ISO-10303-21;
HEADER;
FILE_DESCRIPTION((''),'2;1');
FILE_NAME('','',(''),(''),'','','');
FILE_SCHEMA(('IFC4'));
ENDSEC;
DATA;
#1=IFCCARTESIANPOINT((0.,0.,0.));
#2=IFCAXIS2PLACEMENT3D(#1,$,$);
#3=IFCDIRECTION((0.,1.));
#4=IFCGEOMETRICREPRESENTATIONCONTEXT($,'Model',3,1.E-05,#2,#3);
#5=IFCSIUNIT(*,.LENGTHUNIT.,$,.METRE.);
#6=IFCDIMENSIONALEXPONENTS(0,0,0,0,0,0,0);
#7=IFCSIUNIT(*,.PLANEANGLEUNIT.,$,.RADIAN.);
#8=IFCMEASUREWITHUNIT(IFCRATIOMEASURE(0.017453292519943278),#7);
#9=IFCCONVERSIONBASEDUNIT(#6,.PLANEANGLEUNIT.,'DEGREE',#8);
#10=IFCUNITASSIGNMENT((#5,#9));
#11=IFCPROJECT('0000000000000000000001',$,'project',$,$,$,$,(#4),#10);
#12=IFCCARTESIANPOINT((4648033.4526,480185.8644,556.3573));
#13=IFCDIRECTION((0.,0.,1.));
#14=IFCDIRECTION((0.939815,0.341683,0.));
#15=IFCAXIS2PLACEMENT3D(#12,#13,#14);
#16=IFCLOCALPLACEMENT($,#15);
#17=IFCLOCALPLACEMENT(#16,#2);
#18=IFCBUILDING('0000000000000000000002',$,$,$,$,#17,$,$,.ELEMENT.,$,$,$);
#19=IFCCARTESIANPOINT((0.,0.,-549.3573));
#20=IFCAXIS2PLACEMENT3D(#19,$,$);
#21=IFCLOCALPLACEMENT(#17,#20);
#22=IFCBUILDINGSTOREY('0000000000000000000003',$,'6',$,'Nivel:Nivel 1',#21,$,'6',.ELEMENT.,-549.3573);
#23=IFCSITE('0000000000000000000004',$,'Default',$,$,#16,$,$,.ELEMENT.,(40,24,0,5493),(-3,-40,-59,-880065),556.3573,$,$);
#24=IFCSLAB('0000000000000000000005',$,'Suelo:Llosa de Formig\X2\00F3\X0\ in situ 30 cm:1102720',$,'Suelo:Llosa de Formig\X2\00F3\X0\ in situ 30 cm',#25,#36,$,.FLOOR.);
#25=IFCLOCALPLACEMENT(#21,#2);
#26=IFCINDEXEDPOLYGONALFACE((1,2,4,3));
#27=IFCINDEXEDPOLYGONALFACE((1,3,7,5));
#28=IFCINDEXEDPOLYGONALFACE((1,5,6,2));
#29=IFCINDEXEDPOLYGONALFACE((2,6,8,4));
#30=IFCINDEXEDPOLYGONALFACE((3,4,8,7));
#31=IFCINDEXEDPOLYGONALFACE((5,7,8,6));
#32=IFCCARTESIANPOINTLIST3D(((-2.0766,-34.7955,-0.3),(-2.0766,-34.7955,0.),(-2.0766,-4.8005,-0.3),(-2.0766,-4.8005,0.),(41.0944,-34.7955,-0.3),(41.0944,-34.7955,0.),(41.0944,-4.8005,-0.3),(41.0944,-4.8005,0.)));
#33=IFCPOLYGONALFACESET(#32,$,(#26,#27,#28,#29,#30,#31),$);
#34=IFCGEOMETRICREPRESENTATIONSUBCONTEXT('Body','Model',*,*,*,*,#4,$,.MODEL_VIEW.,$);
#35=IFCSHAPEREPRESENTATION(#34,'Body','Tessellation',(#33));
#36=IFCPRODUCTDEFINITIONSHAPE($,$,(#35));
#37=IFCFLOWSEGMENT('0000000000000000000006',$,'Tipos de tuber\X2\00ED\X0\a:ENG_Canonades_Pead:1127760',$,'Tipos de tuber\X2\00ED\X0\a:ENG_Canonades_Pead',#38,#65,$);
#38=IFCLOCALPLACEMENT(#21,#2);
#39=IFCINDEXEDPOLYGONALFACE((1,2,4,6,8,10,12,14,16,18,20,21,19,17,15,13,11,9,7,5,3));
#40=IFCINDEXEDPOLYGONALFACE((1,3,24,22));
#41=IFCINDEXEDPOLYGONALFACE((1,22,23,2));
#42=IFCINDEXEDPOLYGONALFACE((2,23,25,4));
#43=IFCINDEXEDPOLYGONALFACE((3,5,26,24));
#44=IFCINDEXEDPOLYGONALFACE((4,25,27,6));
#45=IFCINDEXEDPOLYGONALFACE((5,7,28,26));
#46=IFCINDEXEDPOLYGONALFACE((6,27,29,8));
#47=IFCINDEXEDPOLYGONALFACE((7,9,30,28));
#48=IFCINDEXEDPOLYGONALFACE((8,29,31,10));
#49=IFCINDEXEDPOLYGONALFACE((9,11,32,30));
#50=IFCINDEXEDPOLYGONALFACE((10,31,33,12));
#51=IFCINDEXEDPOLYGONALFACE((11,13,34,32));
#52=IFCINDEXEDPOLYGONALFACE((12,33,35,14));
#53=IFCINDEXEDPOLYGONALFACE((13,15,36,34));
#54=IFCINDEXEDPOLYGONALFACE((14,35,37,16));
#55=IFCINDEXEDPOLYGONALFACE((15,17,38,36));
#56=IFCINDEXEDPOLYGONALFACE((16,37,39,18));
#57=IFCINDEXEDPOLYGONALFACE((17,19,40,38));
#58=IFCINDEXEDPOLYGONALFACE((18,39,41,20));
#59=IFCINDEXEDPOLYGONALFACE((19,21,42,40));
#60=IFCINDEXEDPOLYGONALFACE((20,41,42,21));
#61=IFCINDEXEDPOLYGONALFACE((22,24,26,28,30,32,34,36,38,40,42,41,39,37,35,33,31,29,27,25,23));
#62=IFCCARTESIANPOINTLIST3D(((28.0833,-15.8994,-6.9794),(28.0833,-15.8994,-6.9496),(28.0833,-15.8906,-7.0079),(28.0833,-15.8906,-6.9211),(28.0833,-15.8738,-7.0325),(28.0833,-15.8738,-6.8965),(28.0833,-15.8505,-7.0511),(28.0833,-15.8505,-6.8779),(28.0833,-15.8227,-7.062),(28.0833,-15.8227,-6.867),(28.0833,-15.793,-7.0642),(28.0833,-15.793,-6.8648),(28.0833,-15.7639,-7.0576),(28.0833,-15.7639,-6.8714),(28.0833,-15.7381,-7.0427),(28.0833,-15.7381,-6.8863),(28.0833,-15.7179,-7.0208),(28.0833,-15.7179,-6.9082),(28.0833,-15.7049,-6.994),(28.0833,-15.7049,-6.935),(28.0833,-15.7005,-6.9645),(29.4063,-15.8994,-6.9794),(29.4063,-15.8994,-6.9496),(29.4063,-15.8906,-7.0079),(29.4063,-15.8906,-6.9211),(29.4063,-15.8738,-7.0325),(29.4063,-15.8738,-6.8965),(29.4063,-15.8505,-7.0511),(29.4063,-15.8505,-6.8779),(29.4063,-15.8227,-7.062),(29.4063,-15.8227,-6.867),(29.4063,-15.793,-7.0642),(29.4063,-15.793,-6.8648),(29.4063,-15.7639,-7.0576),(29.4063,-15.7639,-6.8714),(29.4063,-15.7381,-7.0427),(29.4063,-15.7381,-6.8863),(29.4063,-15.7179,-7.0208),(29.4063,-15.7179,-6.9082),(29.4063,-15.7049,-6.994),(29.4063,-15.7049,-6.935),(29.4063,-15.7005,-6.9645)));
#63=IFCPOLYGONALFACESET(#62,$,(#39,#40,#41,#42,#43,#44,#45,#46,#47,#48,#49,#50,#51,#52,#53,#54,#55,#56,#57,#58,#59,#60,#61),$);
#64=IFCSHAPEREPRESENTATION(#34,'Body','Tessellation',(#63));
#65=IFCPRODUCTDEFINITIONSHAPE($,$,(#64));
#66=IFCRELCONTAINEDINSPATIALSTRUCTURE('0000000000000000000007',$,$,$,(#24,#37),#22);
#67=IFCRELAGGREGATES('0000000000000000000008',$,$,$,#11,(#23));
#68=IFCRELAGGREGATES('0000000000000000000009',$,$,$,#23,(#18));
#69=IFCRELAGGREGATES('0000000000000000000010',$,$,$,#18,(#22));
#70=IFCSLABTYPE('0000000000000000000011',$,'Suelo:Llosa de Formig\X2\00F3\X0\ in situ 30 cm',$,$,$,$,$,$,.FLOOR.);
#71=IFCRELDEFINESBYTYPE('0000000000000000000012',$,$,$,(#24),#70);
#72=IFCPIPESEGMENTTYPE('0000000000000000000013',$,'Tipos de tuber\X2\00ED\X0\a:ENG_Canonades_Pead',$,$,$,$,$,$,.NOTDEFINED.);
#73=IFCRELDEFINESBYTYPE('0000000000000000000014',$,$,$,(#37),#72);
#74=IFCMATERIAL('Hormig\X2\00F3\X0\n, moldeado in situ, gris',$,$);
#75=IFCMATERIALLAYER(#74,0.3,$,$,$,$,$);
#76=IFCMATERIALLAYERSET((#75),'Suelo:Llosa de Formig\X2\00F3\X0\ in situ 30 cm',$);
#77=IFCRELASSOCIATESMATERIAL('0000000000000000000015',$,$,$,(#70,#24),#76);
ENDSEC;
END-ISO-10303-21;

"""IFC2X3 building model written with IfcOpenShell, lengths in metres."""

from ifc_helpers import new_model, entity, si_unit, converted_unit, direction, frame, frame_2d, origin, origin_2d_with_axis, place, context, subcontext, project, spatial, rectangle, circle, extrude, material, layer, layer_set, layer_usage, type_object, element, save


model = new_model("IFC2X3")

# Units and contexts
model_context = context("Model", 3, precision=1e-05, world=origin(), true_north=direction((0.0, 1.0)))
body_context = subcontext(model_context, "Body", "Model", "MODEL_VIEW")
ifc_project = project(units=[si_unit("LENGTHUNIT", "METRE"), converted_unit("PLANEANGLEUNIT", "DEGREE", entity("IfcRatioMeasure", 0.017453292519943278), si_unit("PLANEANGLEUNIT", "RADIAN"), dimensions=[0, 0, 0, 0, 0, 0, 0])], contexts=[model_context])

# Site, building, storey
site_placement = place(None, frame((4648033.4526, 480185.8644, 556.3573), z_axis=(0.0, 0.0, 1.0), x_axis=(0.939815, 0.341683, 0.0)))
site = spatial("IfcSite", under=ifc_project, at=site_placement, Name="Default", CompositionType="ELEMENT", RefLatitude=(40, 24, 0, 5493), RefLongitude=(-3, -40, -59, -880065), RefElevation=556.3573)
building_placement = place(site_placement, origin())
building = spatial("IfcBuilding", under=site, at=building_placement, CompositionType="ELEMENT")
storey_placement = place(building_placement, frame((0.0, 0.0, -549.3573)))
storey = spatial("IfcBuildingStorey", under=building, at=storey_placement, Name="6", ObjectType="Nivel:Nivel 1", LongName="6", CompositionType="ELEMENT", Elevation=-549.3573)

# Slab
ifc_material = material(Name="Hormigón, moldeado in situ, gris")
ifc_layer = layer(ifc_material, 0.3)
ifc_layer_set = layer_set([ifc_layer], Name="Suelo:Llosa de Formigó in situ 30 cm")
ifc_layer_usage = layer_usage(ifc_layer_set, "AXIS3", "POSITIVE", 0.0)
slab_type = type_object("IfcSlabType", Name="Suelo:Llosa de Formigó in situ 30 cm", PredefinedType="FLOOR", material=ifc_layer_set)
slab_placement = place(storey_placement, origin())
element("IfcSlab", 1, at=slab_placement, inside=storey, type_object=slab_type, material=ifc_layer_usage, Name="Suelo:Llosa de Formigó in situ 30 cm:1102720", ObjectType="Suelo:Llosa de Formigó in situ 30 cm", PredefinedType="FLOOR", context=body_context, shape_type="SweptSolid", body=[
    extrude(rectangle(XDim=29.995, YDim=43.171, at=origin_2d_with_axis()), frame((19.5089, -19.798, 0.0), z_axis=(0.0, 0.0, -1.0), x_axis=(0.0, 1.0, 0.0)), (0.0, 0.0, 1.0), 0.3),
])

# Flow segment
pipe_segment_type = type_object("IfcPipeSegmentType", Name="Tipos de tubería:ENG_Canonades_Pead", PredefinedType="NOTDEFINED")
flow_segment_placement = place(storey_placement, origin())
element("IfcFlowSegment", 2, at=flow_segment_placement, inside=storey, type_object=pipe_segment_type, Name="Tipos de tubería:ENG_Canonades_Pead:1127760", ObjectType="Tipos de tubería:ENG_Canonades_Pead", context=body_context, shape_type="SweptSolid", body=[
    extrude(circle(Radius=0.1, at=frame_2d((0.0, 0.0), x_axis=(1.0, 0.0))), frame((28.0833, -15.8005, -6.9645), z_axis=(1.0, 0.0, 0.0), x_axis=(0.0, 1.0, 0.0)), (0.0, 0.0, 1.0), 1.323),
])

save(model, "model.ifc")
